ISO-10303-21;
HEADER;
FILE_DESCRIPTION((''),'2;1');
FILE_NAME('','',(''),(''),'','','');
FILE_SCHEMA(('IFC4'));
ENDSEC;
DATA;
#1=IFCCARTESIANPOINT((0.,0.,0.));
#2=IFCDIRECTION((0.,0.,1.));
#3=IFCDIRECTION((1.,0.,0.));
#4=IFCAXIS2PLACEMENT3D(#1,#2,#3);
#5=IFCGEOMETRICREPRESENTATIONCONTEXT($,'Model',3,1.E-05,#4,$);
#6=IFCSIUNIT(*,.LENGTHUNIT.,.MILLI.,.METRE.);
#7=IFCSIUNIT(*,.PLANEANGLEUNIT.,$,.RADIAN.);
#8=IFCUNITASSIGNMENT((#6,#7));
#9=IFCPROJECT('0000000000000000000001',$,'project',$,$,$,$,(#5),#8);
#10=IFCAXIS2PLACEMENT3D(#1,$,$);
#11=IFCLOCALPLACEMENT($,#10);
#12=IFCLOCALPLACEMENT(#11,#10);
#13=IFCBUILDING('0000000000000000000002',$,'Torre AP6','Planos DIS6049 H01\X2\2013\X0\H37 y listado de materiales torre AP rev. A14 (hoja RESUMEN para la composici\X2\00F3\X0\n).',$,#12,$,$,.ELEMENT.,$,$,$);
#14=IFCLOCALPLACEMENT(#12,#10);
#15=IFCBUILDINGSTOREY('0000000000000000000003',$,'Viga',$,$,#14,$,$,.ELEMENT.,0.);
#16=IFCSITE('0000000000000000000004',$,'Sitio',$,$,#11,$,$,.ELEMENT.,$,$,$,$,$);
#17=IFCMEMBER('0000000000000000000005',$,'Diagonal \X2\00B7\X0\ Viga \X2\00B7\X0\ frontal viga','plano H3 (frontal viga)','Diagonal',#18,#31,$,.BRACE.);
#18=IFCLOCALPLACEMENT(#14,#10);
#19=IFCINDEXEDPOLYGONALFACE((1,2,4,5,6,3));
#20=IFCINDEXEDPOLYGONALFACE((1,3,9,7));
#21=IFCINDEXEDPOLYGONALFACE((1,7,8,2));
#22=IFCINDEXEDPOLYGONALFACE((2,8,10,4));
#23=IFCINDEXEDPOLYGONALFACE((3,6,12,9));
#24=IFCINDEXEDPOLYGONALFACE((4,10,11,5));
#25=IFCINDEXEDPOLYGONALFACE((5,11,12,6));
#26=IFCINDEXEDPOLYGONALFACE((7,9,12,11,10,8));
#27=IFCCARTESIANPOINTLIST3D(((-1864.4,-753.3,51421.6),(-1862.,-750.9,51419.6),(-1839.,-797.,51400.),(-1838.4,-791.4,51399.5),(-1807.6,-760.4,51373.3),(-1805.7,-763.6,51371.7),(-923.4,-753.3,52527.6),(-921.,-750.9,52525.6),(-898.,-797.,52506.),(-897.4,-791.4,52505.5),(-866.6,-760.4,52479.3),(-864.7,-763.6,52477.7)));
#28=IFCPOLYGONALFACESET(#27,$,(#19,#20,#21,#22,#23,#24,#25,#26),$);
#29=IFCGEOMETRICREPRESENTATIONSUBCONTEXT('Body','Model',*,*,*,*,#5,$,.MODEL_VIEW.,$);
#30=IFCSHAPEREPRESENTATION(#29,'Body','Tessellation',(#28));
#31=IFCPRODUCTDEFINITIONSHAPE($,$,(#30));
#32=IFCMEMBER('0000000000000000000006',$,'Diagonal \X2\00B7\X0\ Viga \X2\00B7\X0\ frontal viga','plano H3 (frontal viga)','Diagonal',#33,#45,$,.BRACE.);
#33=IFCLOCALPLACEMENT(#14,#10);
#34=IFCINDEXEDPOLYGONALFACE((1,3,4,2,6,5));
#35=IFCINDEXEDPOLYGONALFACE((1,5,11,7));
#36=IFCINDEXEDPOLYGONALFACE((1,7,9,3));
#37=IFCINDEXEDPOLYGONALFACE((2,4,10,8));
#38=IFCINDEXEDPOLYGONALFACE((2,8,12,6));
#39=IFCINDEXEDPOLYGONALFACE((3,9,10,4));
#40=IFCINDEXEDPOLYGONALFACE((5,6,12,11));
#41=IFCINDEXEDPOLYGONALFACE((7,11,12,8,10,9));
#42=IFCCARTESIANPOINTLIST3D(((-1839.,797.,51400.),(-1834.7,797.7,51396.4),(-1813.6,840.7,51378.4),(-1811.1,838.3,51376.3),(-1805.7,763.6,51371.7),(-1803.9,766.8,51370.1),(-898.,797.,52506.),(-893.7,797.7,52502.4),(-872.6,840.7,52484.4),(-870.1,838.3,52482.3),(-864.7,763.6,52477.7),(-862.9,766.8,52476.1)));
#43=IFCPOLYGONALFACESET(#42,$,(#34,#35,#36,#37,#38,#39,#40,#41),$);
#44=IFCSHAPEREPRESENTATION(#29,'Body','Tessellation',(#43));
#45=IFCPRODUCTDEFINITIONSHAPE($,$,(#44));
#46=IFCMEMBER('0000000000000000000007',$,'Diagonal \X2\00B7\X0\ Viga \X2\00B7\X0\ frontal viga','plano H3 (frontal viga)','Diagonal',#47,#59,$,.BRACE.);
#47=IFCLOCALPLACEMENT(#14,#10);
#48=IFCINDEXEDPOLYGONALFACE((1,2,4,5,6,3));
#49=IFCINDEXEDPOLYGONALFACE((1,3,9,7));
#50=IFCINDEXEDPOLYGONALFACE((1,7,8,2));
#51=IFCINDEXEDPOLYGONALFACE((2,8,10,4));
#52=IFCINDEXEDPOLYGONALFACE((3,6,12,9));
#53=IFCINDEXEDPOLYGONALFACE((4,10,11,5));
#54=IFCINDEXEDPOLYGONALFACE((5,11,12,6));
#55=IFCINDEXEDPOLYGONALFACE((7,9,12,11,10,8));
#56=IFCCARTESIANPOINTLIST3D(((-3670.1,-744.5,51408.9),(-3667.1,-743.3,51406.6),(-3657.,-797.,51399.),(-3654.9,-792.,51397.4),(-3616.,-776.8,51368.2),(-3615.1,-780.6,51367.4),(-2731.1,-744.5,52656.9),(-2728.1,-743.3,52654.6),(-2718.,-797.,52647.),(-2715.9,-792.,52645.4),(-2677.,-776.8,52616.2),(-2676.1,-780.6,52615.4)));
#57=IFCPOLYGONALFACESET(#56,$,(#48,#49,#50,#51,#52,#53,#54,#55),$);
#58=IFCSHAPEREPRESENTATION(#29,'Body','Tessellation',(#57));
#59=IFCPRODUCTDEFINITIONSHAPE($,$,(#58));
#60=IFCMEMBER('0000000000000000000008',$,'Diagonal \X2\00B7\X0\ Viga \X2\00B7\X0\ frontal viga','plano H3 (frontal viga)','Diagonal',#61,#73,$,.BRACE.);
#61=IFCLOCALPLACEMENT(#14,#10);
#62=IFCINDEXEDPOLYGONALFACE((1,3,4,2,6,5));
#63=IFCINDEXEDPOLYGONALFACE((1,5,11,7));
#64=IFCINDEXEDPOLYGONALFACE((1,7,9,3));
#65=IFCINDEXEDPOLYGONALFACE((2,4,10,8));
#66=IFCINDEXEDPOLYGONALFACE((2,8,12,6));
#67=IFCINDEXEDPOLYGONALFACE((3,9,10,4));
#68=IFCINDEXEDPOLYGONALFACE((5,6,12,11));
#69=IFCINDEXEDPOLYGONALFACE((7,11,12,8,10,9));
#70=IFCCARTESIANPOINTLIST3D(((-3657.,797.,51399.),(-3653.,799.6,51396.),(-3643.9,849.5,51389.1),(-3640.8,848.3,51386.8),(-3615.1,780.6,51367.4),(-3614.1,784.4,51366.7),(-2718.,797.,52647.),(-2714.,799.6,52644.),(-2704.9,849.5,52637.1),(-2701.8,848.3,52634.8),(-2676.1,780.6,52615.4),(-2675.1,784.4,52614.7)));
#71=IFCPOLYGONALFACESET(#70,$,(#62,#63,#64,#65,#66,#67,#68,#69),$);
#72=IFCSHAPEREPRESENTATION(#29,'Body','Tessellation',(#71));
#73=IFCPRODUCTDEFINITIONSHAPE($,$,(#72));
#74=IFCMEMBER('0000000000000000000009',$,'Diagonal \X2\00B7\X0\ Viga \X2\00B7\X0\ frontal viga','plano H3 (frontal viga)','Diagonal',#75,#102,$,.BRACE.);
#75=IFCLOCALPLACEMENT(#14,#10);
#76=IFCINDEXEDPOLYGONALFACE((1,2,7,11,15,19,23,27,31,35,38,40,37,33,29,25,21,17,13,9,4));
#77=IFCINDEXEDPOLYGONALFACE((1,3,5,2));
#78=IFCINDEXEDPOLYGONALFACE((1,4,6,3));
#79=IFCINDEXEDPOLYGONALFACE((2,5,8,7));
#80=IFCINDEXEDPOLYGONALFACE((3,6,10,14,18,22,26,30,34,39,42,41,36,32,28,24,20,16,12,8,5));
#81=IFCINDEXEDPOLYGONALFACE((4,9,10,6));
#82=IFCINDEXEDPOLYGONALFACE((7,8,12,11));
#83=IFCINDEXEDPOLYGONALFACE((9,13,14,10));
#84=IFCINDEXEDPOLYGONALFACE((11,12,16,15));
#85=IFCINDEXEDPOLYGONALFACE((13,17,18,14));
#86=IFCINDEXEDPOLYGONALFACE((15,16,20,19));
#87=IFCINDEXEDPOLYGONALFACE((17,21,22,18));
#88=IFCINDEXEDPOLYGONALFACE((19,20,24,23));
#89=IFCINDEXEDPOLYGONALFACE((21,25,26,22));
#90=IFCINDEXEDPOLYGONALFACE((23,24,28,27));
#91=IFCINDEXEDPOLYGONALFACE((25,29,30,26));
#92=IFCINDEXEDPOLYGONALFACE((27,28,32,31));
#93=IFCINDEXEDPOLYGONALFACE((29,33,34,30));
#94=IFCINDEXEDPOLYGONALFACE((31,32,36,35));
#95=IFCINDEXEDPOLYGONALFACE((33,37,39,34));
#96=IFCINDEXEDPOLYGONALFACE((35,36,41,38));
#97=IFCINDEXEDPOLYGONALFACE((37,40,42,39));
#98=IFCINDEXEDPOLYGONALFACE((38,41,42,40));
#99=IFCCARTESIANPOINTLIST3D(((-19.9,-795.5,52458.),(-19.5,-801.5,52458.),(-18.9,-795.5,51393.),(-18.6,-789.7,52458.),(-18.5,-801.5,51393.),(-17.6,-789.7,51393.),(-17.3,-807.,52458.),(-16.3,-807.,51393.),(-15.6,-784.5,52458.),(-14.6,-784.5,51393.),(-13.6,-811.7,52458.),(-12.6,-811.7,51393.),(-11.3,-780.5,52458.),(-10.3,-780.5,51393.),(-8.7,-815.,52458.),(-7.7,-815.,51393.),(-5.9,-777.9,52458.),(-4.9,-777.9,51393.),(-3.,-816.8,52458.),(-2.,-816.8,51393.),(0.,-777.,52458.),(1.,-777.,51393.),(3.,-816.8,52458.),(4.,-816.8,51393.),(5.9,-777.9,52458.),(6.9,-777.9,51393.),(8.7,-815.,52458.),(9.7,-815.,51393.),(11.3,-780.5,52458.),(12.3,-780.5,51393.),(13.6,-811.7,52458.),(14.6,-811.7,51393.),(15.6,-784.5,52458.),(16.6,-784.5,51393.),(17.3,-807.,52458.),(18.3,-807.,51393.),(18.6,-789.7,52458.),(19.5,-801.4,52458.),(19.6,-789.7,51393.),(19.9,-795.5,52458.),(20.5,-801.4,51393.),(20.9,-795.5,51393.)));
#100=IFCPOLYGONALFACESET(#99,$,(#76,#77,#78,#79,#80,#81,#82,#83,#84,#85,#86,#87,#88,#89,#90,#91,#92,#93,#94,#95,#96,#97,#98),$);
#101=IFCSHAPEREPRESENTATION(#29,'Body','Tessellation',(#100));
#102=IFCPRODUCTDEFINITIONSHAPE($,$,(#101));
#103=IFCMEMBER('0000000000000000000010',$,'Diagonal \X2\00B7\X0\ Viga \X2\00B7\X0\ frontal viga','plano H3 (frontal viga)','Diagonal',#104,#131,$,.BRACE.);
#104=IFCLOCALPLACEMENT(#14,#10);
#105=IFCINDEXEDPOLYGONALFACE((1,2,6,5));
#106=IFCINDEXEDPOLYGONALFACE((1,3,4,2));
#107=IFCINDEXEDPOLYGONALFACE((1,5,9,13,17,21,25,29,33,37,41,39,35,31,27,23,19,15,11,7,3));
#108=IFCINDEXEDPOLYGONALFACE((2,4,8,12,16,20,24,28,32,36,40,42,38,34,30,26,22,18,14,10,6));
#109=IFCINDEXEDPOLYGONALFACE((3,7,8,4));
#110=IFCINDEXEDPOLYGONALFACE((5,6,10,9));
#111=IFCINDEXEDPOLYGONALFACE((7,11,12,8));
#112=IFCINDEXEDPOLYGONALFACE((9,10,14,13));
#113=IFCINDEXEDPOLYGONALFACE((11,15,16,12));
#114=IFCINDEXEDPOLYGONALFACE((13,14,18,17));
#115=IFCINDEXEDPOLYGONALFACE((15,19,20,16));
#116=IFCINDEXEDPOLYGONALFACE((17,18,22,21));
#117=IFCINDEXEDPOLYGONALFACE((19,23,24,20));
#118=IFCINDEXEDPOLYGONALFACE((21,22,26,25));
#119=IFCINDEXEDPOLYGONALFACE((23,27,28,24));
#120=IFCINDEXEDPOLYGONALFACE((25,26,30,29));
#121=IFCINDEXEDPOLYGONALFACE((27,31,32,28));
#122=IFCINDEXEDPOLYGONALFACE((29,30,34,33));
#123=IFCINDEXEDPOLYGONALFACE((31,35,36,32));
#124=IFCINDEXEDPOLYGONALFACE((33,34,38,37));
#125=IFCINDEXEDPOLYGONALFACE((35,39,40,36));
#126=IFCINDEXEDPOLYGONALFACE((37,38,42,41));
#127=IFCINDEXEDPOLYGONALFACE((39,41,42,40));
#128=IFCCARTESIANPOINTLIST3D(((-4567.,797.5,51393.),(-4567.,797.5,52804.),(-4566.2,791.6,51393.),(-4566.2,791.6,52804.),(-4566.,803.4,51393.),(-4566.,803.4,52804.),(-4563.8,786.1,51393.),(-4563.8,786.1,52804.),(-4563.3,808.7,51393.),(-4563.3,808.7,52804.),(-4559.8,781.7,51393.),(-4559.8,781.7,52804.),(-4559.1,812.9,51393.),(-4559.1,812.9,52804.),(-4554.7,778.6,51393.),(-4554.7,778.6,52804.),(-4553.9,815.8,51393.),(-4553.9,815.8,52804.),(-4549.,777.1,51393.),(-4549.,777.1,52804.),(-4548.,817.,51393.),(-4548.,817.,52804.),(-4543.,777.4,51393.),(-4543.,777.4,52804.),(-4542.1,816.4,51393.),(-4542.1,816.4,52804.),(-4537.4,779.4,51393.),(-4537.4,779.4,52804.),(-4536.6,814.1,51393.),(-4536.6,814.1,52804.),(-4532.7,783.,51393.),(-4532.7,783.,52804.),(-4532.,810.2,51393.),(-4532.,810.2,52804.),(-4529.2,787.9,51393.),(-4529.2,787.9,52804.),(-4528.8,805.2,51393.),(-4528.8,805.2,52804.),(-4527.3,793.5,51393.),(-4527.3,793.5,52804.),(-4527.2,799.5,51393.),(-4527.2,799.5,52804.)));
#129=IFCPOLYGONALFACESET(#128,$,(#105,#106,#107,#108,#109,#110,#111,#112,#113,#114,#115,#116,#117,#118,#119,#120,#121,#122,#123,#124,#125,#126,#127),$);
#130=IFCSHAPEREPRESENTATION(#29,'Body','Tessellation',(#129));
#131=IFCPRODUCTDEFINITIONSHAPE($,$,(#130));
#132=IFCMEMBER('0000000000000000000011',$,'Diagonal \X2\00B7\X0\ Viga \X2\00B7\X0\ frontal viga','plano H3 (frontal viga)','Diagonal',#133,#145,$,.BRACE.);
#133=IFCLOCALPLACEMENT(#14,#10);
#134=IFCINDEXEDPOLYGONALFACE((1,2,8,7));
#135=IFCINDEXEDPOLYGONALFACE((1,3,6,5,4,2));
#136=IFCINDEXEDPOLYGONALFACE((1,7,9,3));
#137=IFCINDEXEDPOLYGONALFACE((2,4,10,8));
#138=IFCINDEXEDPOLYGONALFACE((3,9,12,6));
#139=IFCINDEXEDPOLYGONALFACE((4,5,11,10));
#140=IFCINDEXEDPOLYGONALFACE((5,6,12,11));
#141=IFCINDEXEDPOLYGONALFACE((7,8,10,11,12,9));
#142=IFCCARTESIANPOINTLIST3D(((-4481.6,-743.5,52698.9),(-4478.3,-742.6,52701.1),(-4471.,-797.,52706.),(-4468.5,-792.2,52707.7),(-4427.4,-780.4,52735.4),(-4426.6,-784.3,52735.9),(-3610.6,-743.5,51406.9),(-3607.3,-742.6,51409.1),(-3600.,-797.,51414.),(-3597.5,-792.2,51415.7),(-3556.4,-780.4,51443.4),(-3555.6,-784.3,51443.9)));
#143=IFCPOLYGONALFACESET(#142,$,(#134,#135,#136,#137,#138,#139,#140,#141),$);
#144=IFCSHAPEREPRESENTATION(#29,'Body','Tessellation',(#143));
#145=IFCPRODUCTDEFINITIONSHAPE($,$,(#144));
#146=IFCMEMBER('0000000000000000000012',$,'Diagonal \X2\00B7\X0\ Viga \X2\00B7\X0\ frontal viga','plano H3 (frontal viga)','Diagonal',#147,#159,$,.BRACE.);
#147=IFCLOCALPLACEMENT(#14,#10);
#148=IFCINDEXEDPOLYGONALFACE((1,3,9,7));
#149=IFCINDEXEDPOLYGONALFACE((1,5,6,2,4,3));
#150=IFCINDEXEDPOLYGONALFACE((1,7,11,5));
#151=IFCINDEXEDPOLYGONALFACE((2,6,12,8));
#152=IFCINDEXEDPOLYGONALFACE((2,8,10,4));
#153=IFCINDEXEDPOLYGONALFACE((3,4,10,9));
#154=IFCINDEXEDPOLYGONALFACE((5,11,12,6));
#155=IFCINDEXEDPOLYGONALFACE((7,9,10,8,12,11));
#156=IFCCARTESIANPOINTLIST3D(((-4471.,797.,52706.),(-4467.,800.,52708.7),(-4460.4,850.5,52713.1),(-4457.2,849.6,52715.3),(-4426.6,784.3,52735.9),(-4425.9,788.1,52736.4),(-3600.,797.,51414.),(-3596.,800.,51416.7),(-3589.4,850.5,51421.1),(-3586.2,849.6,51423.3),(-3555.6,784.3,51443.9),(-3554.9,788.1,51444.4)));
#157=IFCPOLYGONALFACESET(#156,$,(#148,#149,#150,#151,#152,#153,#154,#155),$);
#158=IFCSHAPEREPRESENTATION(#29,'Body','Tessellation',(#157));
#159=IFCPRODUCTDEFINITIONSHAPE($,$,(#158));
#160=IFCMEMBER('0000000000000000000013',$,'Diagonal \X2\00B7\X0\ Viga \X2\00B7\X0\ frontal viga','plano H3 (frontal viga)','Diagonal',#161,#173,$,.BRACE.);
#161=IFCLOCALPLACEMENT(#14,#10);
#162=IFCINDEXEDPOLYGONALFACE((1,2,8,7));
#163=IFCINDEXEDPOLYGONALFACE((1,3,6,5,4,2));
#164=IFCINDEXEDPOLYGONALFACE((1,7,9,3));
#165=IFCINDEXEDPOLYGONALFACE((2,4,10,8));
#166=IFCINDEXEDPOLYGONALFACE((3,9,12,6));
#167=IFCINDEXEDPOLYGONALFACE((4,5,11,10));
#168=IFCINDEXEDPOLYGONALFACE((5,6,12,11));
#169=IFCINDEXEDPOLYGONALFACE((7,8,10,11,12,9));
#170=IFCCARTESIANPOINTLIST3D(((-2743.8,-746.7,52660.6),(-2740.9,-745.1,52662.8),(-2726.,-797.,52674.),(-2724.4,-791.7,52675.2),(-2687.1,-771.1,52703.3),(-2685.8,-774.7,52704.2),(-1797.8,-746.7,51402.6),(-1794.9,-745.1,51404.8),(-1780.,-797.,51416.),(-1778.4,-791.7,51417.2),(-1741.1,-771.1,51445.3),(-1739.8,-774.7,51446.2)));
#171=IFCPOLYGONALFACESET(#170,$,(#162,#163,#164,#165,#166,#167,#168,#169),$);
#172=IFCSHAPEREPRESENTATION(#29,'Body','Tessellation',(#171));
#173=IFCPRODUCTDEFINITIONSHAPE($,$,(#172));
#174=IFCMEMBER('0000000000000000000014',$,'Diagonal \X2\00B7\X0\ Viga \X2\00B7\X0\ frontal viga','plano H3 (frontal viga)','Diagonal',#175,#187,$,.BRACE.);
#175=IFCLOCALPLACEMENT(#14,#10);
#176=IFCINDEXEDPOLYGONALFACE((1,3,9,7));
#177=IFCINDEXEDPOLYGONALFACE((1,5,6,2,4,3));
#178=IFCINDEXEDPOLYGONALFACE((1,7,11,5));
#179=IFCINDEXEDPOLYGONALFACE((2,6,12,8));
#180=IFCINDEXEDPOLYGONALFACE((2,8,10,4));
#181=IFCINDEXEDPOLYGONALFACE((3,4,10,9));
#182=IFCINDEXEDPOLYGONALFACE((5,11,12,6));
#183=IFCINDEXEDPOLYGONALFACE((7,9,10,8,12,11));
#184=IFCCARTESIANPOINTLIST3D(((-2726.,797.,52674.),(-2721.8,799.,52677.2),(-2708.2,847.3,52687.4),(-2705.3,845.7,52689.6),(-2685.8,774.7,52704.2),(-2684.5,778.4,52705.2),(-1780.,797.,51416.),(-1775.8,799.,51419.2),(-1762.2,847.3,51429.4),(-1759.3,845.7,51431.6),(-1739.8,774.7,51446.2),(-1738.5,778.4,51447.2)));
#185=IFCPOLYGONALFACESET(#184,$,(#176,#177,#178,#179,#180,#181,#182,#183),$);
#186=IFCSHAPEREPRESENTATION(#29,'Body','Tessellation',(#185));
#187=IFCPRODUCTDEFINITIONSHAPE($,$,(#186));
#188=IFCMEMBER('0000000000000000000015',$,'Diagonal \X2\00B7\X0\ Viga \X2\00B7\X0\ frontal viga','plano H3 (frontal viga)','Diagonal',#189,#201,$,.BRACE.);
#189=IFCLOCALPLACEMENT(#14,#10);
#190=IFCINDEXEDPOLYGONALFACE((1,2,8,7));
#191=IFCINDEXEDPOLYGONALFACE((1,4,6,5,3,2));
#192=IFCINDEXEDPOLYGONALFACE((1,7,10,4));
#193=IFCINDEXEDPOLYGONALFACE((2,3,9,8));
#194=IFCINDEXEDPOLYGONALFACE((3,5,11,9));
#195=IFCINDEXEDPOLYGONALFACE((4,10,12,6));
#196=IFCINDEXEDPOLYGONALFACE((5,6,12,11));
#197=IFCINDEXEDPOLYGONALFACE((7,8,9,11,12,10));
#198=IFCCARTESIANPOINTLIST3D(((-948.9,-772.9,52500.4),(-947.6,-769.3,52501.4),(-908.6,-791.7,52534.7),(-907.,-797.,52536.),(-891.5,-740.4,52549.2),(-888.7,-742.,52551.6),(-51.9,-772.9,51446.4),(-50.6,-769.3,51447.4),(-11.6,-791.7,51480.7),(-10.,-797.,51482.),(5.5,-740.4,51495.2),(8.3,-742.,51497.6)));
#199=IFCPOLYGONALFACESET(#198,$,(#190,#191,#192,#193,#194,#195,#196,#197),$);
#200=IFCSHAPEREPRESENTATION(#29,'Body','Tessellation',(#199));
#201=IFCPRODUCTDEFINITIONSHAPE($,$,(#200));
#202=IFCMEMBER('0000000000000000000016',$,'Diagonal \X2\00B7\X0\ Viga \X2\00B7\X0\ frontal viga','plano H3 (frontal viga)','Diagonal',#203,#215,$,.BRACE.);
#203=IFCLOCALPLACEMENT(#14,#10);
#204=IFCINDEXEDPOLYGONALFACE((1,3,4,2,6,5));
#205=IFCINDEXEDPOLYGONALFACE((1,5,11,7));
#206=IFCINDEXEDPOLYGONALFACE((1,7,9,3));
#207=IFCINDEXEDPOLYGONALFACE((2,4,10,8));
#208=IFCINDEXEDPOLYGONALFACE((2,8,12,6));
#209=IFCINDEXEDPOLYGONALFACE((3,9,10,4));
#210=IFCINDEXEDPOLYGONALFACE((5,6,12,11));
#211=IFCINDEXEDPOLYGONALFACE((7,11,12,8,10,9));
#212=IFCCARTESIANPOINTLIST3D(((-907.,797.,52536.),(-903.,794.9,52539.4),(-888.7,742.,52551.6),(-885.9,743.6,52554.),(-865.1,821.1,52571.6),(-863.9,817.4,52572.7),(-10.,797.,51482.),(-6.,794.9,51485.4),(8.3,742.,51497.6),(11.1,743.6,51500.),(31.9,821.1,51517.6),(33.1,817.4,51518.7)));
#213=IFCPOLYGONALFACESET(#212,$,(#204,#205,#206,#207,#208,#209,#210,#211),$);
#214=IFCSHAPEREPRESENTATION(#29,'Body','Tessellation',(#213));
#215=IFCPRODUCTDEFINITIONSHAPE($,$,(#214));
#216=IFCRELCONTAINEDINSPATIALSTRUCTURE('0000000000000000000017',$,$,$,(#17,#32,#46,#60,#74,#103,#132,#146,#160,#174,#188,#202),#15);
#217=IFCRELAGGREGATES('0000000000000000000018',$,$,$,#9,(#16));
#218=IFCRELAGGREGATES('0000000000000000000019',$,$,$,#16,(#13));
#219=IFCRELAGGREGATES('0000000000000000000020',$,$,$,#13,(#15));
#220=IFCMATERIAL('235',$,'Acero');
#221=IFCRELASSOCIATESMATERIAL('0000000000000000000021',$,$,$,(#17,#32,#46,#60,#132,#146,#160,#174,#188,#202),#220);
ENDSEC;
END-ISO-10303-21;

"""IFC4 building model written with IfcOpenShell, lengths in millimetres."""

from ifc_helpers import new_model, si_unit, frame, frame_2d, origin, origin_with_axes, place, context, subcontext, project, spatial, circle, l_section, extrude, material, element, save


model = new_model("IFC4")

# Units and contexts
model_context = context("Model", 3, precision=1e-05, world=origin_with_axes())
body_context = subcontext(model_context, "Body", "Model", "MODEL_VIEW")
ifc_project = project(units=[si_unit("LENGTHUNIT", "METRE", prefix="MILLI"), si_unit("PLANEANGLEUNIT", "RADIAN")], contexts=[model_context])

# Site, building, storey
site_placement = place(None, origin())
site = spatial("IfcSite", under=ifc_project, at=site_placement, Name="Sitio", CompositionType="ELEMENT")
building_placement = place(site_placement, origin())
building = spatial("IfcBuilding", under=site, at=building_placement, Name="Torre AP6", Description="Planos DIS6049 H01–H37 y listado de materiales torre AP rev. A14 (hoja RESUMEN para la composición).", CompositionType="ELEMENT")
storey_placement = place(building_placement, origin())
storey = spatial("IfcBuildingStorey", under=building, at=storey_placement, Name="Viga", CompositionType="ELEMENT", Elevation=0.0)

# Members
ifc_material = material(Name="235", Category="Acero")
for number, where, z_axis, x_axis, name in (
    (1, (-1839.0, -797.0, 51400.0), (0.648008, 0.0, 0.761633), (0.605023, 0.607426, -0.514762), "Diagonal · Viga · frontal viga"),
    (2, (-1839.0, 797.0, 51400.0), (0.648008, 0.0, 0.761633), (0.605023, -0.607426, -0.514762), "Diagonal · Viga · frontal viga"),
):
    element("IfcMember", number, at=place(storey_placement, frame(where, z_axis=z_axis, x_axis=x_axis)), inside=storey, material=ifc_material, Name=name, Description="plano H3 (frontal viga)", ObjectType="Diagonal", PredefinedType="BRACE", context=body_context, shape_type="SweptSolid", body=[
        extrude(l_section(Depth=55.0, Width=55.0, Thickness=4.0, at=frame_2d((27.5, 27.5))), None, (0.0, 0.0, 1.0), 1452.1),
    ])
for number, where, z_axis, x_axis, name in (
    (3, (-3657.0, -797.0, 51399.0), (0.601229, 0.0, 0.799077), (0.762614, 0.298631, -0.573794), "Diagonal · Viga · frontal viga"),
    (4, (-3657.0, 797.0, 51399.0), (0.601229, 0.0, 0.799077), (0.762614, -0.298631, -0.573794), "Diagonal · Viga · frontal viga"),
):
    element("IfcMember", number, at=place(storey_placement, frame(where, z_axis=z_axis, x_axis=x_axis)), inside=storey, material=ifc_material, Name=name, Description="plano H3 (frontal viga)", ObjectType="Diagonal", PredefinedType="BRACE", context=body_context, shape_type="SweptSolid", body=[
        extrude(l_section(Depth=55.0, Width=55.0, Thickness=4.0, at=frame_2d((27.5, 27.5))), None, (0.0, 0.0, 1.0), 1561.8),
    ])
member_1_placement = place(storey_placement, frame((1.0, -797.0, 51393.0), z_axis=(-0.000939, 0.0, 1.0), x_axis=(-0.000627, 1.0, -0.000001)))
element("IfcMember", 5, at=member_1_placement, inside=storey, Name="Diagonal · Viga · frontal viga", Description="plano H3 (frontal viga)", ObjectType="Diagonal", PredefinedType="BRACE", context=body_context, shape_type="SweptSolid", body=[
    extrude(circle(Radius=20.0), None, (0.0, 0.0, 1.0), 1065.0),
])
member_2_placement = place(storey_placement, frame((-4547.0, 797.0, 51393.0), z_axis=(0.0, 0.0, 1.0), x_axis=(0.984984, -0.172648, 0.0)))
element("IfcMember", 6, at=member_2_placement, inside=storey, Name="Diagonal · Viga · frontal viga", Description="plano H3 (frontal viga)", ObjectType="Diagonal", PredefinedType="BRACE", context=body_context, shape_type="SweptSolid", body=[
    extrude(circle(Radius=20.0), None, (0.0, 0.0, 1.0), 1411.0),
])
for number, where, z_axis, x_axis, name in (
    (7, (-3600.0, -797.0, 51414.0), (-0.558988, 0.0, 0.829176), (0.806611, 0.231703, 0.543776), "Diagonal · Viga · frontal viga"),
    (8, (-3600.0, 797.0, 51414.0), (-0.558988, 0.0, 0.829176), (0.806611, -0.231703, 0.543776), "Diagonal · Viga · frontal viga"),
):
    element("IfcMember", number, at=place(storey_placement, frame(where, z_axis=z_axis, x_axis=x_axis)), inside=storey, material=ifc_material, Name=name, Description="plano H3 (frontal viga)", ObjectType="Diagonal", PredefinedType="BRACE", context=body_context, shape_type="SweptSolid", body=[
        extrude(l_section(Depth=55.0, Width=55.0, Thickness=4.0, at=frame_2d((27.5, 27.5))), None, (0.0, 0.0, 1.0), 1558.2),
    ])
for number, where, z_axis, x_axis, name in (
    (9, (-1780.0, -797.0, 51416.0), (-0.601016, 0.0, 0.799237), (0.730849, 0.404737, 0.549589), "Diagonal · Viga · frontal viga"),
    (10, (-1780.0, 797.0, 51416.0), (-0.601016, 0.0, 0.799237), (0.730849, -0.404737, 0.549589), "Diagonal · Viga · frontal viga"),
):
    element("IfcMember", number, at=place(storey_placement, frame(where, z_axis=z_axis, x_axis=x_axis)), inside=storey, material=ifc_material, Name=name, Description="plano H3 (frontal viga)", ObjectType="Diagonal", PredefinedType="BRACE", context=body_context, shape_type="SweptSolid", body=[
        extrude(l_section(Depth=55.0, Width=55.0, Thickness=4.0, at=frame_2d((27.5, 27.5))), None, (0.0, 0.0, 1.0), 1574.0),
    ])
for number, where, z_axis, x_axis, name in (
    (11, (-10.0, -797.0, 51482.0), (-0.64811, 0.0, 0.761547), (0.305596, 0.915954, 0.260076), "Diagonal · Viga · frontal viga"),
    (12, (-10.0, 797.0, 51482.0), (-0.64811, 0.0, 0.761547), (0.305596, -0.915954, 0.260076), "Diagonal · Viga · frontal viga"),
):
    element("IfcMember", number, at=place(storey_placement, frame(where, z_axis=z_axis, x_axis=x_axis)), inside=storey, material=ifc_material, Name=name, Description="plano H3 (frontal viga)", ObjectType="Diagonal", PredefinedType="BRACE", context=body_context, shape_type="SweptSolid", body=[
        extrude(l_section(Depth=60.0, Width=60.0, Thickness=4.0, at=frame_2d((30.0, 30.0))), None, (0.0, 0.0, 1.0), 1384.0),
    ])

save(model, "model.ifc")
